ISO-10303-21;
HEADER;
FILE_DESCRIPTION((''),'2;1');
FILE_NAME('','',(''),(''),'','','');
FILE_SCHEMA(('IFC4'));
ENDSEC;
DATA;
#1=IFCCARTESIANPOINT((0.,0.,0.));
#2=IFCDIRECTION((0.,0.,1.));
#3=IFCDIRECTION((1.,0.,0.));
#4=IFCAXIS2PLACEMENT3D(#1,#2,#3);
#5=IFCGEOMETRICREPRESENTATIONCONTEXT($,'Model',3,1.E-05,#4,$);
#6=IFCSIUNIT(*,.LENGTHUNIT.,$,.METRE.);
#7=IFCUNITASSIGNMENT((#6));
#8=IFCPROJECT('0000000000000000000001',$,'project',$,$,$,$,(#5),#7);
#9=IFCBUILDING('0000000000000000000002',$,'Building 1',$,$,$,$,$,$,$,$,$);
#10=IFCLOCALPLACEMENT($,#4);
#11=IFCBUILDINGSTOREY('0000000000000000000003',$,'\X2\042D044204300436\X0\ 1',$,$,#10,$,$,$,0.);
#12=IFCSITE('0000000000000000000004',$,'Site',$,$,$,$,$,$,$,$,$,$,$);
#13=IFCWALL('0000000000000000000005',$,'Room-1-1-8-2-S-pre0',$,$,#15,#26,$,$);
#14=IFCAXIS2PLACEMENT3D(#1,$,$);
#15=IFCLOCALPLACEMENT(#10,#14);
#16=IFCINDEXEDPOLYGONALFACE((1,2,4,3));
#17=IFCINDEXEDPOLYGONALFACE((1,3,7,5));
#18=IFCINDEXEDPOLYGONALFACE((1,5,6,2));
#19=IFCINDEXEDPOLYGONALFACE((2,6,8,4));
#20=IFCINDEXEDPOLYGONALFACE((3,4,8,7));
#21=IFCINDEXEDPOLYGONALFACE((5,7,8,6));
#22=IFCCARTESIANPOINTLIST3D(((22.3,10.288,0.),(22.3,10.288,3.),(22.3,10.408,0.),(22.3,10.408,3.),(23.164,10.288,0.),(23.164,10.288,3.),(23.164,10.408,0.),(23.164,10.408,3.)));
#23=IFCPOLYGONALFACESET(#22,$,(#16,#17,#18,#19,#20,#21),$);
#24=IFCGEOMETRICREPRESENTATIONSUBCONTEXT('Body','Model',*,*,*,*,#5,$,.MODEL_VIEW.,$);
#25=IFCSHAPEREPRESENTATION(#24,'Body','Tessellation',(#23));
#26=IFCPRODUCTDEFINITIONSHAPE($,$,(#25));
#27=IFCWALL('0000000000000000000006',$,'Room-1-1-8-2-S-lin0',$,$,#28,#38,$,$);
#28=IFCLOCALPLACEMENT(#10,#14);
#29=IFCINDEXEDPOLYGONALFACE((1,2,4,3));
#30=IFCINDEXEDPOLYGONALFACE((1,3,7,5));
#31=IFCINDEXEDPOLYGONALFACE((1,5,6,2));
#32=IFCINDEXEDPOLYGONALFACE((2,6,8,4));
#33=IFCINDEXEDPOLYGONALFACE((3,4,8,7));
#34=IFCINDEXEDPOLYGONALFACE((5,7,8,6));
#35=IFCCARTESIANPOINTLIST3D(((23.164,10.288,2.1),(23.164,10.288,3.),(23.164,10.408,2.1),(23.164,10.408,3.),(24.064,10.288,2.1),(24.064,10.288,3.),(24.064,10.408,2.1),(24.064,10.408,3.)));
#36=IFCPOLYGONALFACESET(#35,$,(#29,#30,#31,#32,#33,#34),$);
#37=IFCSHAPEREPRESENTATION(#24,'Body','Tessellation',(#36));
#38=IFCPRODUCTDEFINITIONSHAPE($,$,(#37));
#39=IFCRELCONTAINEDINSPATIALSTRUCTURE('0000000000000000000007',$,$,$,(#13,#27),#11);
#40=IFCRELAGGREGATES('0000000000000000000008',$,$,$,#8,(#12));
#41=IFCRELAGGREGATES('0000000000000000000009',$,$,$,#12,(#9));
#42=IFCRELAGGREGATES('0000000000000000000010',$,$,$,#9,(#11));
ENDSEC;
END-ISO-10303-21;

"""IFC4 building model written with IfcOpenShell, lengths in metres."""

from ifc_helpers import new_model, si_unit, frame, origin_with_axes, place, context, subcontext, project, spatial, indexed_curve, outline, extrude, element, save


model = new_model("IFC4")

# Units and contexts
model_context = context("Model", 3, precision=1e-05, world=origin_with_axes())
body_context = subcontext(model_context, "Body", "Model", "MODEL_VIEW")
ifc_project = project(units=[si_unit("LENGTHUNIT", "METRE")], contexts=[model_context])

# Site, building, storey
site = spatial("IfcSite", under=ifc_project, Name="Site")
building = spatial("IfcBuilding", under=site, Name="Building 1")
storey_placement = place(None, origin_with_axes())
storey = spatial("IfcBuildingStorey", under=building, at=storey_placement, Name="Этаж 1", Elevation=0.0)

# Walls
wall_1_placement = place(storey_placement, frame((22.3, 10.288, 0.0), z_axis=(0.0, 0.0, 1.0), x_axis=(1.0, 0.0, 0.0)))
element("IfcWall", 1, at=wall_1_placement, inside=storey, Name="Room-1-1-8-2-S-pre0", context=body_context, shape_type="SweptSolid", body=[
    extrude(outline(indexed_curve([(0.0, 0.0), (0.0, 0.12), (0.864, 0.12), (0.864, 0.0), (0.0, 0.0)], self_intersect=False)), origin_with_axes(), (0.0, 0.0, 1.0), 3.0),
])
wall_2_placement = place(storey_placement, frame((23.164, 10.288, 2.1), z_axis=(0.0, 0.0, 1.0), x_axis=(1.0, 0.0, 0.0)))
element("IfcWall", 2, at=wall_2_placement, inside=storey, Name="Room-1-1-8-2-S-lin0", context=body_context, shape_type="SweptSolid", body=[
    extrude(outline(indexed_curve([(0.0, 0.0), (0.0, 0.12), (0.9, 0.12), (0.9, 0.0), (0.0, 0.0)], self_intersect=False)), origin_with_axes(), (0.0, 0.0, 1.0), 0.9),
])

save(model, "model.ifc")
